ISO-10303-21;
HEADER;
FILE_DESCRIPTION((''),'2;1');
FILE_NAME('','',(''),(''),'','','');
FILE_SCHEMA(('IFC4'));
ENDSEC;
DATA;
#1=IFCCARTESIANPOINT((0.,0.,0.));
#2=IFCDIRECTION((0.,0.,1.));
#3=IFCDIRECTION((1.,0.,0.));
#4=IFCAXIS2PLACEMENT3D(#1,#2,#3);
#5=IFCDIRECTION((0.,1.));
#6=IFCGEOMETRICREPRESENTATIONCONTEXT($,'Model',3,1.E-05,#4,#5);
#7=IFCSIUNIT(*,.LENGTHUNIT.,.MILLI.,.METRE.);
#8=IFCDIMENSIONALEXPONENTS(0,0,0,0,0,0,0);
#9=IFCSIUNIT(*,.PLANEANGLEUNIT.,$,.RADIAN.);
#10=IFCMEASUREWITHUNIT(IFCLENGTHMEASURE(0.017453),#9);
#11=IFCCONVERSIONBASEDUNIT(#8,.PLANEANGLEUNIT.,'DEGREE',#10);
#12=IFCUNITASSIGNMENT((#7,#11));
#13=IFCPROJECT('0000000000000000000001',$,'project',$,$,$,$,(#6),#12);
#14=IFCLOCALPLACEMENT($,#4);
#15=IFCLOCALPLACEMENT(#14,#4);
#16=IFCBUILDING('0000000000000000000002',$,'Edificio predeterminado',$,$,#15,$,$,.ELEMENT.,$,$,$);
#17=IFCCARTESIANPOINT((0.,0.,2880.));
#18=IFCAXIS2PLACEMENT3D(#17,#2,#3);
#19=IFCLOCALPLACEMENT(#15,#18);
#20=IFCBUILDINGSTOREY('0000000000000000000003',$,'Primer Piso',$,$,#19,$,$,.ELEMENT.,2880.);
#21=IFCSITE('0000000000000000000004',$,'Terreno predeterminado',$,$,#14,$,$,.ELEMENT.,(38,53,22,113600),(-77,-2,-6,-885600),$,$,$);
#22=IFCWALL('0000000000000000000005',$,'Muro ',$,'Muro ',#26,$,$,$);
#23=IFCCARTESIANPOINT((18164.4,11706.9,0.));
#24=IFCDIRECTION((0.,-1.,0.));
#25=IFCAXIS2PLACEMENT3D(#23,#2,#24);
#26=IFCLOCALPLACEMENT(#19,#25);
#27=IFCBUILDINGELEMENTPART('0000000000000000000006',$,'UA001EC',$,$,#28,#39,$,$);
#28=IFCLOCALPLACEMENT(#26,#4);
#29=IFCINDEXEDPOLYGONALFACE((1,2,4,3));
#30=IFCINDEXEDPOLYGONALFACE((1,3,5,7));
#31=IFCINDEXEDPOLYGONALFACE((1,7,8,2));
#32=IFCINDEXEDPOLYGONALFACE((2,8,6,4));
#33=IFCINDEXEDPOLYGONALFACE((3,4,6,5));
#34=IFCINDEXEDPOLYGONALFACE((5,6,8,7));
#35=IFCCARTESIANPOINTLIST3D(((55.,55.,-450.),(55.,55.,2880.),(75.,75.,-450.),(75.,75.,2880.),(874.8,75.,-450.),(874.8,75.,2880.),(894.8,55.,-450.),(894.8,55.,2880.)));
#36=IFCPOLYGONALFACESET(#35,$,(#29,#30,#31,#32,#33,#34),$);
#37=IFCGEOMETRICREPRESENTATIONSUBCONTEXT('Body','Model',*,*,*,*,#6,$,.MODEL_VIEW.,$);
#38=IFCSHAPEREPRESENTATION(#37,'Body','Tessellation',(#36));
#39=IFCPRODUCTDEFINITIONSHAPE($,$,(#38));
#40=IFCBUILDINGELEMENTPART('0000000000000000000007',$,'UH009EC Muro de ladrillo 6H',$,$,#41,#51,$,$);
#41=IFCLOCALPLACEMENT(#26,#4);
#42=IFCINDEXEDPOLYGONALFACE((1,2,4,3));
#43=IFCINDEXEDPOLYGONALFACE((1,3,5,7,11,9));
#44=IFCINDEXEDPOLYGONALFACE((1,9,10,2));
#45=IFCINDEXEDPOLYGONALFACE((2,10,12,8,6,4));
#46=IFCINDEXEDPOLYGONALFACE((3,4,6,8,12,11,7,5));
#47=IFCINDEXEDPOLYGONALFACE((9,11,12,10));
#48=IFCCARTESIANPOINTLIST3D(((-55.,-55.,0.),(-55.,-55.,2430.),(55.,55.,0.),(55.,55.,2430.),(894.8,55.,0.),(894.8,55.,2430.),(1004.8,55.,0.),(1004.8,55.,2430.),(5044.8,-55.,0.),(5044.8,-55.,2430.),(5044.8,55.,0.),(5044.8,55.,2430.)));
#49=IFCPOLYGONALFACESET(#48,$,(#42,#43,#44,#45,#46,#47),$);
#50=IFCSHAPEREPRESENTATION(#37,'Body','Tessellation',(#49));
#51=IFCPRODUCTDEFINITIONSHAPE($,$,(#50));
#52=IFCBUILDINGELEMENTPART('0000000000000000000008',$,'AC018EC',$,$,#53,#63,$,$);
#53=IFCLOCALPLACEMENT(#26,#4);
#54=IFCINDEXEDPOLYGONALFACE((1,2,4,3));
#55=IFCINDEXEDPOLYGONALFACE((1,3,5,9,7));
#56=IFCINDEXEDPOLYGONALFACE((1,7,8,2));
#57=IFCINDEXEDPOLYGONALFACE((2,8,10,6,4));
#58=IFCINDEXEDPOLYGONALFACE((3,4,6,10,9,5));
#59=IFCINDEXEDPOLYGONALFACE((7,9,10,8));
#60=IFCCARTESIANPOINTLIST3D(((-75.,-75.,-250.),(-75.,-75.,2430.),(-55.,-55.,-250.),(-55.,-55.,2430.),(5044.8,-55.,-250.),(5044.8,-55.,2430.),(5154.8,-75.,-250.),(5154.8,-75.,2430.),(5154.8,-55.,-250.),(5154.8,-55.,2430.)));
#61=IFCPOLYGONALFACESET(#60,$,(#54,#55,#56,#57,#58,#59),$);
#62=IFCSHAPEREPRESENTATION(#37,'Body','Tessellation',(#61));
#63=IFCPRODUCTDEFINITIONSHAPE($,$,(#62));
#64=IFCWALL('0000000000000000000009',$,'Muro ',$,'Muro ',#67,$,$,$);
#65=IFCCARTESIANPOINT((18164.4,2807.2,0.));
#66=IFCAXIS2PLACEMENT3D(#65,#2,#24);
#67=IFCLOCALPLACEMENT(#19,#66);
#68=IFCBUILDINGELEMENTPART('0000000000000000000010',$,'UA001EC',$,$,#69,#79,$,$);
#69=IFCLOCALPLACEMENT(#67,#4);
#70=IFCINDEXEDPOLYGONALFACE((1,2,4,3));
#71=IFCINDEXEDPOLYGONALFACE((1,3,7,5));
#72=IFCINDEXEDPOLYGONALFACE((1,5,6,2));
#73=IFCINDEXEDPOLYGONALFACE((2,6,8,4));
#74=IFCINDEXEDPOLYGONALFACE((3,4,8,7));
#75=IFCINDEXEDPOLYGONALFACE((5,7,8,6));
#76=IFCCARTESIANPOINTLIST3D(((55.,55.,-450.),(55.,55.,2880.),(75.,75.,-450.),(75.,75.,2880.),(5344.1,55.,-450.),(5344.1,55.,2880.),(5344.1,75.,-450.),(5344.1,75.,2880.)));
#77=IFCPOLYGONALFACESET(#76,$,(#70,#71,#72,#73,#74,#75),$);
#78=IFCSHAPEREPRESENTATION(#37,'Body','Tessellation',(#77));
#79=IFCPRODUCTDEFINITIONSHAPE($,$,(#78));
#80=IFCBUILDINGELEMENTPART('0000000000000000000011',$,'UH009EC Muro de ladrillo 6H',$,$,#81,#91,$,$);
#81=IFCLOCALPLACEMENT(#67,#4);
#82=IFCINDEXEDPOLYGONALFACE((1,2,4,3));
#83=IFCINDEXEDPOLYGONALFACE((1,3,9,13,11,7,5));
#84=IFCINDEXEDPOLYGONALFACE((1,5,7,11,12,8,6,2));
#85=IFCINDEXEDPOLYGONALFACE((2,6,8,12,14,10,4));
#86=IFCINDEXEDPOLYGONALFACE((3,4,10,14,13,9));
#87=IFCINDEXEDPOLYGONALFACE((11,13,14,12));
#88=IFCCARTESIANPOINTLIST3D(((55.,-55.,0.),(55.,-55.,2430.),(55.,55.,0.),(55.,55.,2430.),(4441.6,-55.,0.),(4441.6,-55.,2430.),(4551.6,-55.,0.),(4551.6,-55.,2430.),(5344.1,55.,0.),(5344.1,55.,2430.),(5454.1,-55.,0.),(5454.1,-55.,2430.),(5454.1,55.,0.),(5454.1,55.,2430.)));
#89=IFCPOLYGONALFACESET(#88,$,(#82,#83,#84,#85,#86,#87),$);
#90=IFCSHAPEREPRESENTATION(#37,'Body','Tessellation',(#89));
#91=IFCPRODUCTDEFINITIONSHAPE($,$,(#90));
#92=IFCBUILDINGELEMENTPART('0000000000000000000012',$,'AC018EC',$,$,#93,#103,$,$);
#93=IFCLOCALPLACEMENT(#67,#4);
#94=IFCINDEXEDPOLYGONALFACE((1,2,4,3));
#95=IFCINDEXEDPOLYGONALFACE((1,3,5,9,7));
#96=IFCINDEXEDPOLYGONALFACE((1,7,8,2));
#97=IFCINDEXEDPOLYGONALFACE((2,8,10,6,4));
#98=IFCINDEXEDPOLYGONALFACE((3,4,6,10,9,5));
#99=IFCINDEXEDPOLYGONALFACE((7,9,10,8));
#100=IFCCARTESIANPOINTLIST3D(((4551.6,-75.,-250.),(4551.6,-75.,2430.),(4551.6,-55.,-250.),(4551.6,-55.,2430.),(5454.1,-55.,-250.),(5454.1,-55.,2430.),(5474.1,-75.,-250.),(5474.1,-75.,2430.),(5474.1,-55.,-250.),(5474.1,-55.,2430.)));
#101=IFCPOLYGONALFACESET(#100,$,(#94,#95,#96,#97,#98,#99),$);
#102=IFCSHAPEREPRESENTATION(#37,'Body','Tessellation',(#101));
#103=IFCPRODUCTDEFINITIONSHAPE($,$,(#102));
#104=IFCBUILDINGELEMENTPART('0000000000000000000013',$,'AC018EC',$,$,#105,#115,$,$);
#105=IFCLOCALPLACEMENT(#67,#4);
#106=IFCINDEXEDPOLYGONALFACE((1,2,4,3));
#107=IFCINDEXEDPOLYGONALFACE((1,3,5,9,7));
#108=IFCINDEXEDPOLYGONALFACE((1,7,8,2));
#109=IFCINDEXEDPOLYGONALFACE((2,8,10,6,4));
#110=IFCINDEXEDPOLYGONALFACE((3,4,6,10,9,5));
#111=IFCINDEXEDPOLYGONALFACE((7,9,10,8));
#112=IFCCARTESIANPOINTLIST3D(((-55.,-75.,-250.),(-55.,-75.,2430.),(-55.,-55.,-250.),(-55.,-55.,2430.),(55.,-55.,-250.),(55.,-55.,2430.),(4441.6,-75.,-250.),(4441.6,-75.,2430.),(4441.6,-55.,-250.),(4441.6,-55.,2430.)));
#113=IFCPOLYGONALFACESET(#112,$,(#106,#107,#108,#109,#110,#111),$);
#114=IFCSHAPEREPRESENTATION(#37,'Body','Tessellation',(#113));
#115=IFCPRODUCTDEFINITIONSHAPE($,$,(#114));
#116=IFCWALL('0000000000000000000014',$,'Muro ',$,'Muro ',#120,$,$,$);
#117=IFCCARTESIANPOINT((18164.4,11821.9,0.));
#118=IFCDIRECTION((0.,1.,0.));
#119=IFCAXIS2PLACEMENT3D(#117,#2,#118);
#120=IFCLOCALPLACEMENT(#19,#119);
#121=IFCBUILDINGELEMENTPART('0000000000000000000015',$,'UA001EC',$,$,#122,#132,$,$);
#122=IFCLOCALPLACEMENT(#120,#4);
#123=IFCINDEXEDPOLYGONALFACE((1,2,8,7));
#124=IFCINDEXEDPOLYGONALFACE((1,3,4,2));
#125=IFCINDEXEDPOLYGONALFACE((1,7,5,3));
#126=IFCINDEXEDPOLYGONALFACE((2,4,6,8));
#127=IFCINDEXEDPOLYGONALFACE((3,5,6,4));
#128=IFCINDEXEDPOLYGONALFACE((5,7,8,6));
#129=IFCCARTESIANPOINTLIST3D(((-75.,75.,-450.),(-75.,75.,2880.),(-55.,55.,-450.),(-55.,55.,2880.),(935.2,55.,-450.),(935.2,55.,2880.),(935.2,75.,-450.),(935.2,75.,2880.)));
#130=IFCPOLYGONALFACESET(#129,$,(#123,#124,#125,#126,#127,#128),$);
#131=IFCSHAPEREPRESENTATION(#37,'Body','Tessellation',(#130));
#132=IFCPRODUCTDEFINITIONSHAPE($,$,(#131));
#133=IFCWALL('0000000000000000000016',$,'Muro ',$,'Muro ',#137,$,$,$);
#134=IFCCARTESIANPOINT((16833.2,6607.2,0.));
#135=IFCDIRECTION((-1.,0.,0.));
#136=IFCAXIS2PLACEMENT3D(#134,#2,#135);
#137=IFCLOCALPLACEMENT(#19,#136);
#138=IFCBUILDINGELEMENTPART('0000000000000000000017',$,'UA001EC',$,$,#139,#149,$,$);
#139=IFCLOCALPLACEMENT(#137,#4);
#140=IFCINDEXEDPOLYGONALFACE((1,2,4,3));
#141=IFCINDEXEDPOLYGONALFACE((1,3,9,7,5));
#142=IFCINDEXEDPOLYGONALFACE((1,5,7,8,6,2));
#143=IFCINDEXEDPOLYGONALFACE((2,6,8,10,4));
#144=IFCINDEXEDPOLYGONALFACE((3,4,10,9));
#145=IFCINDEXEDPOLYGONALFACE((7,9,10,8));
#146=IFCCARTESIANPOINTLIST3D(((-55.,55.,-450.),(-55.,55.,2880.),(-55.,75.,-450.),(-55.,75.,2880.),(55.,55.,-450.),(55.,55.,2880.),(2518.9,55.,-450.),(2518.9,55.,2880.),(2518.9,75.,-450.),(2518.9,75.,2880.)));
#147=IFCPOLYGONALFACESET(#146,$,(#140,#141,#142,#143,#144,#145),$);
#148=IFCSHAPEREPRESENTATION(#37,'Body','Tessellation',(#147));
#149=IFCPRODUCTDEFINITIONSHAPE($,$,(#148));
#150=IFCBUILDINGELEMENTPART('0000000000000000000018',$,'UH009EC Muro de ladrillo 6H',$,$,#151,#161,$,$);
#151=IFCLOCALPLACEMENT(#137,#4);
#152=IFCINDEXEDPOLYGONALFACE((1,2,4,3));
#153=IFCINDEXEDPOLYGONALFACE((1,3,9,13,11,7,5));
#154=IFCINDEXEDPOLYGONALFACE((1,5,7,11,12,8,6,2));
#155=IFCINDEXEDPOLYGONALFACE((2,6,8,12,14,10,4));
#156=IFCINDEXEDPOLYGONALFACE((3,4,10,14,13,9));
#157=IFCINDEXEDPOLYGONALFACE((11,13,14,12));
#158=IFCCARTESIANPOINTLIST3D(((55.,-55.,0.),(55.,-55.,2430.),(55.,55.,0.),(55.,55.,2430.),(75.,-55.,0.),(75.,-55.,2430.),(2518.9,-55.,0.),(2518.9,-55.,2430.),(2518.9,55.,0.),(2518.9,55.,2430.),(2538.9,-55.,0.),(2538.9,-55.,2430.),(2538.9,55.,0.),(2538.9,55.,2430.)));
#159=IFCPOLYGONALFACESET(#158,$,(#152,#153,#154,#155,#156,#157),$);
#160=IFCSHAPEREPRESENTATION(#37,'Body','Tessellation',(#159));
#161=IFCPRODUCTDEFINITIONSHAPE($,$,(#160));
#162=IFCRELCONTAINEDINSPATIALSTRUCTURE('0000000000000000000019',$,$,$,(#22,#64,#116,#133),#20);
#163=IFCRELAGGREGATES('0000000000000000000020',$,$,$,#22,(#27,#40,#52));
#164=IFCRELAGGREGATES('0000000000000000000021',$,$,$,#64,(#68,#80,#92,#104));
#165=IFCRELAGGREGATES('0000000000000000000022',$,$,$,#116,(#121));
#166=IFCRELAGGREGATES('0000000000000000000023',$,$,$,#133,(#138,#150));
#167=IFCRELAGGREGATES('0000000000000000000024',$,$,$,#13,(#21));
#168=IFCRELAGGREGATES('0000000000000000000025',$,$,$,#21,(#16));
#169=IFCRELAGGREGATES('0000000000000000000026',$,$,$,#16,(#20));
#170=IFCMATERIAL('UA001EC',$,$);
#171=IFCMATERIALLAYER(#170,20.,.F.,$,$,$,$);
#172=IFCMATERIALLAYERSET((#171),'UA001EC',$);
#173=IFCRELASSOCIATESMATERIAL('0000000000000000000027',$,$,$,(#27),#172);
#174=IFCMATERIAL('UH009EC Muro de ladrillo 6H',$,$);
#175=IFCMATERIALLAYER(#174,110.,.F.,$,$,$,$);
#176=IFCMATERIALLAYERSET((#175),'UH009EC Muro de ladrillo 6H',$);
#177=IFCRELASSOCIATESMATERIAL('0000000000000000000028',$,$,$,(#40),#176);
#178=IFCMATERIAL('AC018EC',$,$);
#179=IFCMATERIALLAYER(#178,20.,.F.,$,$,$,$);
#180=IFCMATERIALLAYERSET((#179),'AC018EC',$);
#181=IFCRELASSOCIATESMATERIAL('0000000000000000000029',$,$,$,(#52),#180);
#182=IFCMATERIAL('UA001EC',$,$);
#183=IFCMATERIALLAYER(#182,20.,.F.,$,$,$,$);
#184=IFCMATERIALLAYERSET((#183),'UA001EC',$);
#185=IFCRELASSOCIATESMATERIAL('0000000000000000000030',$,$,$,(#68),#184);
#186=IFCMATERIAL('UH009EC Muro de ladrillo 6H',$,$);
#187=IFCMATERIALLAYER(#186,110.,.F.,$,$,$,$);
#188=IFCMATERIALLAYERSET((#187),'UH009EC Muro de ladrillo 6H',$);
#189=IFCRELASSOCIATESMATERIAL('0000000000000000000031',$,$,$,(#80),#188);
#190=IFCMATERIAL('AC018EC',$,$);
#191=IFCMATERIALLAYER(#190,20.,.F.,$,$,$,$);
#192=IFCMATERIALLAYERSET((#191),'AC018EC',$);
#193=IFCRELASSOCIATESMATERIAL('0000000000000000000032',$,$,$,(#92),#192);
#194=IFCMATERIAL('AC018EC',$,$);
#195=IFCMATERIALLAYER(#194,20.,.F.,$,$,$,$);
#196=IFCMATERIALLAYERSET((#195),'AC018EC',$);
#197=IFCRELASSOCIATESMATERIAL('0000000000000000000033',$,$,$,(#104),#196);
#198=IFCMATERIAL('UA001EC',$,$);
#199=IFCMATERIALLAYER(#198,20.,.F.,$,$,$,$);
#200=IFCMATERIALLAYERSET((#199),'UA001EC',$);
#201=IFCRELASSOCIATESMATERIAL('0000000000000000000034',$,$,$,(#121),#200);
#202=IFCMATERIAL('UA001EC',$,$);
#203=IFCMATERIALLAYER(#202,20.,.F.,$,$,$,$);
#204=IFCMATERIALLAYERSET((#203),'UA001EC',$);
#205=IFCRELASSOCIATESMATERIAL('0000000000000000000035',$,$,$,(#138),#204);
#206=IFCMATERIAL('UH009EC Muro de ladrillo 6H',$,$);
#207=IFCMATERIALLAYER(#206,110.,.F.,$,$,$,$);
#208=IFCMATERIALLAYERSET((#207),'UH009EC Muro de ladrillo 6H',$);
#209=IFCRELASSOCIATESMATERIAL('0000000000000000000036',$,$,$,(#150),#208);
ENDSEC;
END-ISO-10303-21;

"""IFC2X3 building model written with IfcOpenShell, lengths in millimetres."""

from ifc_helpers import new_model, entity, si_unit, converted_unit, direction, frame, origin_with_axes, place, context, subcontext, project, spatial, polyline, outline, extrude, material, layer, layer_set, layer_usage, element, aggregate, save


model = new_model("IFC2X3")

# Units and contexts
model_context = context("Model", 3, precision=1e-05, world=origin_with_axes(), true_north=direction((0.0, 1.0)))
body_context = subcontext(model_context, "Body", "Model", "MODEL_VIEW")
ifc_project = project(units=[si_unit("LENGTHUNIT", "METRE", prefix="MILLI"), converted_unit("PLANEANGLEUNIT", "DEGREE", entity("IfcLengthMeasure", 0.017453), si_unit("PLANEANGLEUNIT", "RADIAN"), dimensions=[0, 0, 0, 0, 0, 0, 0])], contexts=[model_context])

# Site, building, storey
site_placement = place(None, origin_with_axes())
site = spatial("IfcSite", under=ifc_project, at=site_placement, Name="Terreno predeterminado", CompositionType="ELEMENT", RefLatitude=(38, 53, 22, 113600), RefLongitude=(-77, -2, -6, -885600))
building_placement = place(site_placement, origin_with_axes())
building = spatial("IfcBuilding", under=site, at=building_placement, Name="Edificio predeterminado", CompositionType="ELEMENT")
storey_placement = place(building_placement, frame((0.0, 0.0, 2880.0), z_axis=(0.0, 0.0, 1.0), x_axis=(1.0, 0.0, 0.0)))
storey = spatial("IfcBuildingStorey", under=building, at=storey_placement, Name="Primer Piso", CompositionType="ELEMENT", Elevation=2880.0)

# Walls, building element parts
wall_1_placement = place(storey_placement, frame((18164.4, 11706.9, 0.0), z_axis=(0.0, 0.0, 1.0), x_axis=(0.0, -1.0, 0.0)))
wall_1 = element("IfcWall", 1, at=wall_1_placement, inside=storey, Name="Muro ", ObjectType="Muro ")
ifc_material_1 = material(Name="UA001EC")
ifc_layer_1 = layer(ifc_material_1, 20.0, ventilated=False)
ifc_layer_set_1 = layer_set([ifc_layer_1], Name="UA001EC")
ifc_layer_usage_1 = layer_usage(ifc_layer_set_1, "AXIS2", "NEGATIVE", -75.0)
building_element_part_1_placement = place(wall_1_placement, origin_with_axes())
building_element_part_1 = element("IfcBuildingElementPart", 2, at=building_element_part_1_placement, material=ifc_layer_usage_1, Name="UA001EC", context=body_context, shape_type="SweptSolid", body=[
    extrude(outline(polyline([(874.8, 75.0), (894.8, 55.0), (55.0, 55.0), (75.0, 75.0), (874.8, 75.0)])), frame((0.0, 0.0, -450.0), z_axis=(0.0, 0.0, 1.0), x_axis=(1.0, 0.0, 0.0)), (0.0, 0.0, 1.0), 3330.0),
])
ifc_material_2 = material(Name="UH009EC Muro de ladrillo 6H")
ifc_layer_2 = layer(ifc_material_2, 110.0, ventilated=False)
ifc_layer_set_2 = layer_set([ifc_layer_2], Name="UH009EC Muro de ladrillo 6H")
ifc_layer_usage_2 = layer_usage(ifc_layer_set_2, "AXIS2", "NEGATIVE", -55.0)
building_element_part_2_placement = place(wall_1_placement, origin_with_axes())
building_element_part_2 = element("IfcBuildingElementPart", 3, at=building_element_part_2_placement, material=ifc_layer_usage_2, Name="UH009EC Muro de ladrillo 6H", context=body_context, shape_type="SweptSolid", body=[
    extrude(outline(polyline([(5044.8, 55.0), (5044.8, -55.0), (-55.0, -55.0), (55.0, 55.0), (894.8, 55.0), (1004.8, 55.0), (5044.8, 55.0)])), origin_with_axes(), (0.0, 0.0, 1.0), 2430.0),
])
ifc_material_3 = material(Name="AC018EC")
ifc_layer_3 = layer(ifc_material_3, 20.0, ventilated=False)
ifc_layer_set_3 = layer_set([ifc_layer_3], Name="AC018EC")
ifc_layer_usage_3 = layer_usage(ifc_layer_set_3, "AXIS2", "NEGATIVE", 55.0)
building_element_part_3_placement = place(wall_1_placement, origin_with_axes())
building_element_part_3 = element("IfcBuildingElementPart", 4, at=building_element_part_3_placement, material=ifc_layer_usage_3, Name="AC018EC", context=body_context, shape_type="SweptSolid", body=[
    extrude(outline(polyline([(5154.8, -55.0), (5154.8, -75.0), (-75.0, -75.0), (-55.0, -55.0), (5044.8, -55.0), (5154.8, -55.0)])), frame((0.0, 0.0, -250.0), z_axis=(0.0, 0.0, 1.0), x_axis=(1.0, 0.0, 0.0)), (0.0, 0.0, 1.0), 2680.0),
])
aggregate(wall_1, [building_element_part_1, building_element_part_2, building_element_part_3])
wall_2_placement = place(storey_placement, frame((18164.4, 2807.2, 0.0), z_axis=(0.0, 0.0, 1.0), x_axis=(0.0, -1.0, 0.0)))
wall_2 = element("IfcWall", 5, at=wall_2_placement, inside=storey, Name="Muro ", ObjectType="Muro ")
ifc_material_4 = material(Name="UA001EC")
ifc_layer_4 = layer(ifc_material_4, 20.0, ventilated=False)
ifc_layer_set_4 = layer_set([ifc_layer_4], Name="UA001EC")
ifc_layer_usage_4 = layer_usage(ifc_layer_set_4, "AXIS2", "NEGATIVE", -75.0)
building_element_part_4_placement = place(wall_2_placement, origin_with_axes())
building_element_part_4 = element("IfcBuildingElementPart", 6, at=building_element_part_4_placement, material=ifc_layer_usage_4, Name="UA001EC", context=body_context, shape_type="SweptSolid", body=[
    extrude(outline(polyline([(5344.1, 75.0), (5344.1, 55.0), (55.0, 55.0), (75.0, 75.0), (5344.1, 75.0)])), frame((0.0, 0.0, -450.0), z_axis=(0.0, 0.0, 1.0), x_axis=(1.0, 0.0, 0.0)), (0.0, 0.0, 1.0), 3330.0),
])
ifc_material_5 = material(Name="UH009EC Muro de ladrillo 6H")
ifc_layer_5 = layer(ifc_material_5, 110.0, ventilated=False)
ifc_layer_set_5 = layer_set([ifc_layer_5], Name="UH009EC Muro de ladrillo 6H")
ifc_layer_usage_5 = layer_usage(ifc_layer_set_5, "AXIS2", "NEGATIVE", -55.0)
building_element_part_5_placement = place(wall_2_placement, origin_with_axes())
building_element_part_5 = element("IfcBuildingElementPart", 7, at=building_element_part_5_placement, material=ifc_layer_usage_5, Name="UH009EC Muro de ladrillo 6H", context=body_context, shape_type="SweptSolid", body=[
    extrude(outline(polyline([(5454.1, 55.0), (5454.1, -55.0), (4551.6, -55.0), (4441.6, -55.0), (55.0, -55.0), (55.0, 55.0), (5344.1, 55.0), (5454.1, 55.0)])), origin_with_axes(), (0.0, 0.0, 1.0), 2430.0),
])
ifc_material_6 = material(Name="AC018EC")
ifc_layer_6 = layer(ifc_material_6, 20.0, ventilated=False)
ifc_layer_set_6 = layer_set([ifc_layer_6], Name="AC018EC")
ifc_layer_usage_6 = layer_usage(ifc_layer_set_6, "AXIS2", "NEGATIVE", 55.0)
building_element_part_6_placement = place(wall_2_placement, origin_with_axes())
building_element_part_6 = element("IfcBuildingElementPart", 8, at=building_element_part_6_placement, material=ifc_layer_usage_6, Name="AC018EC", context=body_context, shape_type="SweptSolid", body=[
    extrude(outline(polyline([(5474.1, -55.0), (5474.1, -75.0), (4551.6, -75.0), (4551.6, -55.0), (5454.1, -55.0), (5474.1, -55.0)])), frame((0.0, 0.0, -250.0), z_axis=(0.0, 0.0, 1.0), x_axis=(1.0, 0.0, 0.0)), (0.0, 0.0, 1.0), 2680.0),
])
ifc_material_7 = material(Name="AC018EC")
ifc_layer_7 = layer(ifc_material_7, 20.0, ventilated=False)
ifc_layer_set_7 = layer_set([ifc_layer_7], Name="AC018EC")
ifc_layer_usage_7 = layer_usage(ifc_layer_set_7, "AXIS2", "NEGATIVE", 55.0)
building_element_part_7_placement = place(wall_2_placement, origin_with_axes())
building_element_part_7 = element("IfcBuildingElementPart", 9, at=building_element_part_7_placement, material=ifc_layer_usage_7, Name="AC018EC", context=body_context, shape_type="SweptSolid", body=[
    extrude(outline(polyline([(4441.6, -55.0), (4441.6, -75.0), (-55.0, -75.0), (-55.0, -55.0), (55.0, -55.0), (4441.6, -55.0)])), frame((0.0, 0.0, -250.0), z_axis=(0.0, 0.0, 1.0), x_axis=(1.0, 0.0, 0.0)), (0.0, 0.0, 1.0), 2680.0),
])
aggregate(wall_2, [building_element_part_4, building_element_part_5, building_element_part_6, building_element_part_7])

# Wall, building element part
wall_3_placement = place(storey_placement, frame((18164.4, 11821.9, 0.0), z_axis=(0.0, 0.0, 1.0), x_axis=(0.0, 1.0, 0.0)))
wall_3 = element("IfcWall", 10, at=wall_3_placement, inside=storey, Name="Muro ", ObjectType="Muro ")
ifc_material_8 = material(Name="UA001EC")
ifc_layer_8 = layer(ifc_material_8, 20.0, ventilated=False)
ifc_layer_set_8 = layer_set([ifc_layer_8], Name="UA001EC")
ifc_layer_usage_8 = layer_usage(ifc_layer_set_8, "AXIS2", "NEGATIVE", -75.0)
building_element_part_8_placement = place(wall_3_placement, origin_with_axes())
building_element_part_8 = element("IfcBuildingElementPart", 11, at=building_element_part_8_placement, material=ifc_layer_usage_8, Name="UA001EC", context=body_context, shape_type="SweptSolid", body=[
    extrude(outline(polyline([(935.2, 75.0), (935.2, 55.0), (-55.0, 55.0), (-75.0, 75.0), (935.2, 75.0)])), frame((0.0, 0.0, -450.0), z_axis=(0.0, 0.0, 1.0), x_axis=(1.0, 0.0, 0.0)), (0.0, 0.0, 1.0), 3330.0),
])
aggregate(wall_3, [building_element_part_8])

# Wall, building element parts
wall_4_placement = place(storey_placement, frame((16833.2, 6607.2, 0.0), z_axis=(0.0, 0.0, 1.0), x_axis=(-1.0, 0.0, 0.0)))
wall_4 = element("IfcWall", 12, at=wall_4_placement, inside=storey, Name="Muro ", ObjectType="Muro ")
ifc_material_9 = material(Name="UA001EC")
ifc_layer_9 = layer(ifc_material_9, 20.0, ventilated=False)
ifc_layer_set_9 = layer_set([ifc_layer_9], Name="UA001EC")
ifc_layer_usage_9 = layer_usage(ifc_layer_set_9, "AXIS2", "NEGATIVE", -75.0)
building_element_part_9_placement = place(wall_4_placement, origin_with_axes())
building_element_part_9 = element("IfcBuildingElementPart", 13, at=building_element_part_9_placement, material=ifc_layer_usage_9, Name="UA001EC", context=body_context, shape_type="SweptSolid", body=[
    extrude(outline(polyline([(2518.9, 75.0), (2518.9, 55.0), (55.0, 55.0), (-55.0, 55.0), (-55.0, 75.0), (2518.9, 75.0)])), frame((0.0, 0.0, -450.0), z_axis=(0.0, 0.0, 1.0), x_axis=(1.0, 0.0, 0.0)), (0.0, 0.0, 1.0), 3330.0),
])
ifc_material_10 = material(Name="UH009EC Muro de ladrillo 6H")
ifc_layer_10 = layer(ifc_material_10, 110.0, ventilated=False)
ifc_layer_set_10 = layer_set([ifc_layer_10], Name="UH009EC Muro de ladrillo 6H")
ifc_layer_usage_10 = layer_usage(ifc_layer_set_10, "AXIS2", "NEGATIVE", -55.0)
building_element_part_10_placement = place(wall_4_placement, origin_with_axes())
building_element_part_10 = element("IfcBuildingElementPart", 14, at=building_element_part_10_placement, material=ifc_layer_usage_10, Name="UH009EC Muro de ladrillo 6H", context=body_context, shape_type="SweptSolid", body=[
    extrude(outline(polyline([(2538.9, 55.0), (2538.9, -55.0), (2518.9, -55.0), (75.0, -55.0), (55.0, -55.0), (55.0, 55.0), (2518.9, 55.0), (2538.9, 55.0)])), origin_with_axes(), (0.0, 0.0, 1.0), 2430.0),
])
aggregate(wall_4, [building_element_part_9, building_element_part_10])

save(model, "model.ifc")
